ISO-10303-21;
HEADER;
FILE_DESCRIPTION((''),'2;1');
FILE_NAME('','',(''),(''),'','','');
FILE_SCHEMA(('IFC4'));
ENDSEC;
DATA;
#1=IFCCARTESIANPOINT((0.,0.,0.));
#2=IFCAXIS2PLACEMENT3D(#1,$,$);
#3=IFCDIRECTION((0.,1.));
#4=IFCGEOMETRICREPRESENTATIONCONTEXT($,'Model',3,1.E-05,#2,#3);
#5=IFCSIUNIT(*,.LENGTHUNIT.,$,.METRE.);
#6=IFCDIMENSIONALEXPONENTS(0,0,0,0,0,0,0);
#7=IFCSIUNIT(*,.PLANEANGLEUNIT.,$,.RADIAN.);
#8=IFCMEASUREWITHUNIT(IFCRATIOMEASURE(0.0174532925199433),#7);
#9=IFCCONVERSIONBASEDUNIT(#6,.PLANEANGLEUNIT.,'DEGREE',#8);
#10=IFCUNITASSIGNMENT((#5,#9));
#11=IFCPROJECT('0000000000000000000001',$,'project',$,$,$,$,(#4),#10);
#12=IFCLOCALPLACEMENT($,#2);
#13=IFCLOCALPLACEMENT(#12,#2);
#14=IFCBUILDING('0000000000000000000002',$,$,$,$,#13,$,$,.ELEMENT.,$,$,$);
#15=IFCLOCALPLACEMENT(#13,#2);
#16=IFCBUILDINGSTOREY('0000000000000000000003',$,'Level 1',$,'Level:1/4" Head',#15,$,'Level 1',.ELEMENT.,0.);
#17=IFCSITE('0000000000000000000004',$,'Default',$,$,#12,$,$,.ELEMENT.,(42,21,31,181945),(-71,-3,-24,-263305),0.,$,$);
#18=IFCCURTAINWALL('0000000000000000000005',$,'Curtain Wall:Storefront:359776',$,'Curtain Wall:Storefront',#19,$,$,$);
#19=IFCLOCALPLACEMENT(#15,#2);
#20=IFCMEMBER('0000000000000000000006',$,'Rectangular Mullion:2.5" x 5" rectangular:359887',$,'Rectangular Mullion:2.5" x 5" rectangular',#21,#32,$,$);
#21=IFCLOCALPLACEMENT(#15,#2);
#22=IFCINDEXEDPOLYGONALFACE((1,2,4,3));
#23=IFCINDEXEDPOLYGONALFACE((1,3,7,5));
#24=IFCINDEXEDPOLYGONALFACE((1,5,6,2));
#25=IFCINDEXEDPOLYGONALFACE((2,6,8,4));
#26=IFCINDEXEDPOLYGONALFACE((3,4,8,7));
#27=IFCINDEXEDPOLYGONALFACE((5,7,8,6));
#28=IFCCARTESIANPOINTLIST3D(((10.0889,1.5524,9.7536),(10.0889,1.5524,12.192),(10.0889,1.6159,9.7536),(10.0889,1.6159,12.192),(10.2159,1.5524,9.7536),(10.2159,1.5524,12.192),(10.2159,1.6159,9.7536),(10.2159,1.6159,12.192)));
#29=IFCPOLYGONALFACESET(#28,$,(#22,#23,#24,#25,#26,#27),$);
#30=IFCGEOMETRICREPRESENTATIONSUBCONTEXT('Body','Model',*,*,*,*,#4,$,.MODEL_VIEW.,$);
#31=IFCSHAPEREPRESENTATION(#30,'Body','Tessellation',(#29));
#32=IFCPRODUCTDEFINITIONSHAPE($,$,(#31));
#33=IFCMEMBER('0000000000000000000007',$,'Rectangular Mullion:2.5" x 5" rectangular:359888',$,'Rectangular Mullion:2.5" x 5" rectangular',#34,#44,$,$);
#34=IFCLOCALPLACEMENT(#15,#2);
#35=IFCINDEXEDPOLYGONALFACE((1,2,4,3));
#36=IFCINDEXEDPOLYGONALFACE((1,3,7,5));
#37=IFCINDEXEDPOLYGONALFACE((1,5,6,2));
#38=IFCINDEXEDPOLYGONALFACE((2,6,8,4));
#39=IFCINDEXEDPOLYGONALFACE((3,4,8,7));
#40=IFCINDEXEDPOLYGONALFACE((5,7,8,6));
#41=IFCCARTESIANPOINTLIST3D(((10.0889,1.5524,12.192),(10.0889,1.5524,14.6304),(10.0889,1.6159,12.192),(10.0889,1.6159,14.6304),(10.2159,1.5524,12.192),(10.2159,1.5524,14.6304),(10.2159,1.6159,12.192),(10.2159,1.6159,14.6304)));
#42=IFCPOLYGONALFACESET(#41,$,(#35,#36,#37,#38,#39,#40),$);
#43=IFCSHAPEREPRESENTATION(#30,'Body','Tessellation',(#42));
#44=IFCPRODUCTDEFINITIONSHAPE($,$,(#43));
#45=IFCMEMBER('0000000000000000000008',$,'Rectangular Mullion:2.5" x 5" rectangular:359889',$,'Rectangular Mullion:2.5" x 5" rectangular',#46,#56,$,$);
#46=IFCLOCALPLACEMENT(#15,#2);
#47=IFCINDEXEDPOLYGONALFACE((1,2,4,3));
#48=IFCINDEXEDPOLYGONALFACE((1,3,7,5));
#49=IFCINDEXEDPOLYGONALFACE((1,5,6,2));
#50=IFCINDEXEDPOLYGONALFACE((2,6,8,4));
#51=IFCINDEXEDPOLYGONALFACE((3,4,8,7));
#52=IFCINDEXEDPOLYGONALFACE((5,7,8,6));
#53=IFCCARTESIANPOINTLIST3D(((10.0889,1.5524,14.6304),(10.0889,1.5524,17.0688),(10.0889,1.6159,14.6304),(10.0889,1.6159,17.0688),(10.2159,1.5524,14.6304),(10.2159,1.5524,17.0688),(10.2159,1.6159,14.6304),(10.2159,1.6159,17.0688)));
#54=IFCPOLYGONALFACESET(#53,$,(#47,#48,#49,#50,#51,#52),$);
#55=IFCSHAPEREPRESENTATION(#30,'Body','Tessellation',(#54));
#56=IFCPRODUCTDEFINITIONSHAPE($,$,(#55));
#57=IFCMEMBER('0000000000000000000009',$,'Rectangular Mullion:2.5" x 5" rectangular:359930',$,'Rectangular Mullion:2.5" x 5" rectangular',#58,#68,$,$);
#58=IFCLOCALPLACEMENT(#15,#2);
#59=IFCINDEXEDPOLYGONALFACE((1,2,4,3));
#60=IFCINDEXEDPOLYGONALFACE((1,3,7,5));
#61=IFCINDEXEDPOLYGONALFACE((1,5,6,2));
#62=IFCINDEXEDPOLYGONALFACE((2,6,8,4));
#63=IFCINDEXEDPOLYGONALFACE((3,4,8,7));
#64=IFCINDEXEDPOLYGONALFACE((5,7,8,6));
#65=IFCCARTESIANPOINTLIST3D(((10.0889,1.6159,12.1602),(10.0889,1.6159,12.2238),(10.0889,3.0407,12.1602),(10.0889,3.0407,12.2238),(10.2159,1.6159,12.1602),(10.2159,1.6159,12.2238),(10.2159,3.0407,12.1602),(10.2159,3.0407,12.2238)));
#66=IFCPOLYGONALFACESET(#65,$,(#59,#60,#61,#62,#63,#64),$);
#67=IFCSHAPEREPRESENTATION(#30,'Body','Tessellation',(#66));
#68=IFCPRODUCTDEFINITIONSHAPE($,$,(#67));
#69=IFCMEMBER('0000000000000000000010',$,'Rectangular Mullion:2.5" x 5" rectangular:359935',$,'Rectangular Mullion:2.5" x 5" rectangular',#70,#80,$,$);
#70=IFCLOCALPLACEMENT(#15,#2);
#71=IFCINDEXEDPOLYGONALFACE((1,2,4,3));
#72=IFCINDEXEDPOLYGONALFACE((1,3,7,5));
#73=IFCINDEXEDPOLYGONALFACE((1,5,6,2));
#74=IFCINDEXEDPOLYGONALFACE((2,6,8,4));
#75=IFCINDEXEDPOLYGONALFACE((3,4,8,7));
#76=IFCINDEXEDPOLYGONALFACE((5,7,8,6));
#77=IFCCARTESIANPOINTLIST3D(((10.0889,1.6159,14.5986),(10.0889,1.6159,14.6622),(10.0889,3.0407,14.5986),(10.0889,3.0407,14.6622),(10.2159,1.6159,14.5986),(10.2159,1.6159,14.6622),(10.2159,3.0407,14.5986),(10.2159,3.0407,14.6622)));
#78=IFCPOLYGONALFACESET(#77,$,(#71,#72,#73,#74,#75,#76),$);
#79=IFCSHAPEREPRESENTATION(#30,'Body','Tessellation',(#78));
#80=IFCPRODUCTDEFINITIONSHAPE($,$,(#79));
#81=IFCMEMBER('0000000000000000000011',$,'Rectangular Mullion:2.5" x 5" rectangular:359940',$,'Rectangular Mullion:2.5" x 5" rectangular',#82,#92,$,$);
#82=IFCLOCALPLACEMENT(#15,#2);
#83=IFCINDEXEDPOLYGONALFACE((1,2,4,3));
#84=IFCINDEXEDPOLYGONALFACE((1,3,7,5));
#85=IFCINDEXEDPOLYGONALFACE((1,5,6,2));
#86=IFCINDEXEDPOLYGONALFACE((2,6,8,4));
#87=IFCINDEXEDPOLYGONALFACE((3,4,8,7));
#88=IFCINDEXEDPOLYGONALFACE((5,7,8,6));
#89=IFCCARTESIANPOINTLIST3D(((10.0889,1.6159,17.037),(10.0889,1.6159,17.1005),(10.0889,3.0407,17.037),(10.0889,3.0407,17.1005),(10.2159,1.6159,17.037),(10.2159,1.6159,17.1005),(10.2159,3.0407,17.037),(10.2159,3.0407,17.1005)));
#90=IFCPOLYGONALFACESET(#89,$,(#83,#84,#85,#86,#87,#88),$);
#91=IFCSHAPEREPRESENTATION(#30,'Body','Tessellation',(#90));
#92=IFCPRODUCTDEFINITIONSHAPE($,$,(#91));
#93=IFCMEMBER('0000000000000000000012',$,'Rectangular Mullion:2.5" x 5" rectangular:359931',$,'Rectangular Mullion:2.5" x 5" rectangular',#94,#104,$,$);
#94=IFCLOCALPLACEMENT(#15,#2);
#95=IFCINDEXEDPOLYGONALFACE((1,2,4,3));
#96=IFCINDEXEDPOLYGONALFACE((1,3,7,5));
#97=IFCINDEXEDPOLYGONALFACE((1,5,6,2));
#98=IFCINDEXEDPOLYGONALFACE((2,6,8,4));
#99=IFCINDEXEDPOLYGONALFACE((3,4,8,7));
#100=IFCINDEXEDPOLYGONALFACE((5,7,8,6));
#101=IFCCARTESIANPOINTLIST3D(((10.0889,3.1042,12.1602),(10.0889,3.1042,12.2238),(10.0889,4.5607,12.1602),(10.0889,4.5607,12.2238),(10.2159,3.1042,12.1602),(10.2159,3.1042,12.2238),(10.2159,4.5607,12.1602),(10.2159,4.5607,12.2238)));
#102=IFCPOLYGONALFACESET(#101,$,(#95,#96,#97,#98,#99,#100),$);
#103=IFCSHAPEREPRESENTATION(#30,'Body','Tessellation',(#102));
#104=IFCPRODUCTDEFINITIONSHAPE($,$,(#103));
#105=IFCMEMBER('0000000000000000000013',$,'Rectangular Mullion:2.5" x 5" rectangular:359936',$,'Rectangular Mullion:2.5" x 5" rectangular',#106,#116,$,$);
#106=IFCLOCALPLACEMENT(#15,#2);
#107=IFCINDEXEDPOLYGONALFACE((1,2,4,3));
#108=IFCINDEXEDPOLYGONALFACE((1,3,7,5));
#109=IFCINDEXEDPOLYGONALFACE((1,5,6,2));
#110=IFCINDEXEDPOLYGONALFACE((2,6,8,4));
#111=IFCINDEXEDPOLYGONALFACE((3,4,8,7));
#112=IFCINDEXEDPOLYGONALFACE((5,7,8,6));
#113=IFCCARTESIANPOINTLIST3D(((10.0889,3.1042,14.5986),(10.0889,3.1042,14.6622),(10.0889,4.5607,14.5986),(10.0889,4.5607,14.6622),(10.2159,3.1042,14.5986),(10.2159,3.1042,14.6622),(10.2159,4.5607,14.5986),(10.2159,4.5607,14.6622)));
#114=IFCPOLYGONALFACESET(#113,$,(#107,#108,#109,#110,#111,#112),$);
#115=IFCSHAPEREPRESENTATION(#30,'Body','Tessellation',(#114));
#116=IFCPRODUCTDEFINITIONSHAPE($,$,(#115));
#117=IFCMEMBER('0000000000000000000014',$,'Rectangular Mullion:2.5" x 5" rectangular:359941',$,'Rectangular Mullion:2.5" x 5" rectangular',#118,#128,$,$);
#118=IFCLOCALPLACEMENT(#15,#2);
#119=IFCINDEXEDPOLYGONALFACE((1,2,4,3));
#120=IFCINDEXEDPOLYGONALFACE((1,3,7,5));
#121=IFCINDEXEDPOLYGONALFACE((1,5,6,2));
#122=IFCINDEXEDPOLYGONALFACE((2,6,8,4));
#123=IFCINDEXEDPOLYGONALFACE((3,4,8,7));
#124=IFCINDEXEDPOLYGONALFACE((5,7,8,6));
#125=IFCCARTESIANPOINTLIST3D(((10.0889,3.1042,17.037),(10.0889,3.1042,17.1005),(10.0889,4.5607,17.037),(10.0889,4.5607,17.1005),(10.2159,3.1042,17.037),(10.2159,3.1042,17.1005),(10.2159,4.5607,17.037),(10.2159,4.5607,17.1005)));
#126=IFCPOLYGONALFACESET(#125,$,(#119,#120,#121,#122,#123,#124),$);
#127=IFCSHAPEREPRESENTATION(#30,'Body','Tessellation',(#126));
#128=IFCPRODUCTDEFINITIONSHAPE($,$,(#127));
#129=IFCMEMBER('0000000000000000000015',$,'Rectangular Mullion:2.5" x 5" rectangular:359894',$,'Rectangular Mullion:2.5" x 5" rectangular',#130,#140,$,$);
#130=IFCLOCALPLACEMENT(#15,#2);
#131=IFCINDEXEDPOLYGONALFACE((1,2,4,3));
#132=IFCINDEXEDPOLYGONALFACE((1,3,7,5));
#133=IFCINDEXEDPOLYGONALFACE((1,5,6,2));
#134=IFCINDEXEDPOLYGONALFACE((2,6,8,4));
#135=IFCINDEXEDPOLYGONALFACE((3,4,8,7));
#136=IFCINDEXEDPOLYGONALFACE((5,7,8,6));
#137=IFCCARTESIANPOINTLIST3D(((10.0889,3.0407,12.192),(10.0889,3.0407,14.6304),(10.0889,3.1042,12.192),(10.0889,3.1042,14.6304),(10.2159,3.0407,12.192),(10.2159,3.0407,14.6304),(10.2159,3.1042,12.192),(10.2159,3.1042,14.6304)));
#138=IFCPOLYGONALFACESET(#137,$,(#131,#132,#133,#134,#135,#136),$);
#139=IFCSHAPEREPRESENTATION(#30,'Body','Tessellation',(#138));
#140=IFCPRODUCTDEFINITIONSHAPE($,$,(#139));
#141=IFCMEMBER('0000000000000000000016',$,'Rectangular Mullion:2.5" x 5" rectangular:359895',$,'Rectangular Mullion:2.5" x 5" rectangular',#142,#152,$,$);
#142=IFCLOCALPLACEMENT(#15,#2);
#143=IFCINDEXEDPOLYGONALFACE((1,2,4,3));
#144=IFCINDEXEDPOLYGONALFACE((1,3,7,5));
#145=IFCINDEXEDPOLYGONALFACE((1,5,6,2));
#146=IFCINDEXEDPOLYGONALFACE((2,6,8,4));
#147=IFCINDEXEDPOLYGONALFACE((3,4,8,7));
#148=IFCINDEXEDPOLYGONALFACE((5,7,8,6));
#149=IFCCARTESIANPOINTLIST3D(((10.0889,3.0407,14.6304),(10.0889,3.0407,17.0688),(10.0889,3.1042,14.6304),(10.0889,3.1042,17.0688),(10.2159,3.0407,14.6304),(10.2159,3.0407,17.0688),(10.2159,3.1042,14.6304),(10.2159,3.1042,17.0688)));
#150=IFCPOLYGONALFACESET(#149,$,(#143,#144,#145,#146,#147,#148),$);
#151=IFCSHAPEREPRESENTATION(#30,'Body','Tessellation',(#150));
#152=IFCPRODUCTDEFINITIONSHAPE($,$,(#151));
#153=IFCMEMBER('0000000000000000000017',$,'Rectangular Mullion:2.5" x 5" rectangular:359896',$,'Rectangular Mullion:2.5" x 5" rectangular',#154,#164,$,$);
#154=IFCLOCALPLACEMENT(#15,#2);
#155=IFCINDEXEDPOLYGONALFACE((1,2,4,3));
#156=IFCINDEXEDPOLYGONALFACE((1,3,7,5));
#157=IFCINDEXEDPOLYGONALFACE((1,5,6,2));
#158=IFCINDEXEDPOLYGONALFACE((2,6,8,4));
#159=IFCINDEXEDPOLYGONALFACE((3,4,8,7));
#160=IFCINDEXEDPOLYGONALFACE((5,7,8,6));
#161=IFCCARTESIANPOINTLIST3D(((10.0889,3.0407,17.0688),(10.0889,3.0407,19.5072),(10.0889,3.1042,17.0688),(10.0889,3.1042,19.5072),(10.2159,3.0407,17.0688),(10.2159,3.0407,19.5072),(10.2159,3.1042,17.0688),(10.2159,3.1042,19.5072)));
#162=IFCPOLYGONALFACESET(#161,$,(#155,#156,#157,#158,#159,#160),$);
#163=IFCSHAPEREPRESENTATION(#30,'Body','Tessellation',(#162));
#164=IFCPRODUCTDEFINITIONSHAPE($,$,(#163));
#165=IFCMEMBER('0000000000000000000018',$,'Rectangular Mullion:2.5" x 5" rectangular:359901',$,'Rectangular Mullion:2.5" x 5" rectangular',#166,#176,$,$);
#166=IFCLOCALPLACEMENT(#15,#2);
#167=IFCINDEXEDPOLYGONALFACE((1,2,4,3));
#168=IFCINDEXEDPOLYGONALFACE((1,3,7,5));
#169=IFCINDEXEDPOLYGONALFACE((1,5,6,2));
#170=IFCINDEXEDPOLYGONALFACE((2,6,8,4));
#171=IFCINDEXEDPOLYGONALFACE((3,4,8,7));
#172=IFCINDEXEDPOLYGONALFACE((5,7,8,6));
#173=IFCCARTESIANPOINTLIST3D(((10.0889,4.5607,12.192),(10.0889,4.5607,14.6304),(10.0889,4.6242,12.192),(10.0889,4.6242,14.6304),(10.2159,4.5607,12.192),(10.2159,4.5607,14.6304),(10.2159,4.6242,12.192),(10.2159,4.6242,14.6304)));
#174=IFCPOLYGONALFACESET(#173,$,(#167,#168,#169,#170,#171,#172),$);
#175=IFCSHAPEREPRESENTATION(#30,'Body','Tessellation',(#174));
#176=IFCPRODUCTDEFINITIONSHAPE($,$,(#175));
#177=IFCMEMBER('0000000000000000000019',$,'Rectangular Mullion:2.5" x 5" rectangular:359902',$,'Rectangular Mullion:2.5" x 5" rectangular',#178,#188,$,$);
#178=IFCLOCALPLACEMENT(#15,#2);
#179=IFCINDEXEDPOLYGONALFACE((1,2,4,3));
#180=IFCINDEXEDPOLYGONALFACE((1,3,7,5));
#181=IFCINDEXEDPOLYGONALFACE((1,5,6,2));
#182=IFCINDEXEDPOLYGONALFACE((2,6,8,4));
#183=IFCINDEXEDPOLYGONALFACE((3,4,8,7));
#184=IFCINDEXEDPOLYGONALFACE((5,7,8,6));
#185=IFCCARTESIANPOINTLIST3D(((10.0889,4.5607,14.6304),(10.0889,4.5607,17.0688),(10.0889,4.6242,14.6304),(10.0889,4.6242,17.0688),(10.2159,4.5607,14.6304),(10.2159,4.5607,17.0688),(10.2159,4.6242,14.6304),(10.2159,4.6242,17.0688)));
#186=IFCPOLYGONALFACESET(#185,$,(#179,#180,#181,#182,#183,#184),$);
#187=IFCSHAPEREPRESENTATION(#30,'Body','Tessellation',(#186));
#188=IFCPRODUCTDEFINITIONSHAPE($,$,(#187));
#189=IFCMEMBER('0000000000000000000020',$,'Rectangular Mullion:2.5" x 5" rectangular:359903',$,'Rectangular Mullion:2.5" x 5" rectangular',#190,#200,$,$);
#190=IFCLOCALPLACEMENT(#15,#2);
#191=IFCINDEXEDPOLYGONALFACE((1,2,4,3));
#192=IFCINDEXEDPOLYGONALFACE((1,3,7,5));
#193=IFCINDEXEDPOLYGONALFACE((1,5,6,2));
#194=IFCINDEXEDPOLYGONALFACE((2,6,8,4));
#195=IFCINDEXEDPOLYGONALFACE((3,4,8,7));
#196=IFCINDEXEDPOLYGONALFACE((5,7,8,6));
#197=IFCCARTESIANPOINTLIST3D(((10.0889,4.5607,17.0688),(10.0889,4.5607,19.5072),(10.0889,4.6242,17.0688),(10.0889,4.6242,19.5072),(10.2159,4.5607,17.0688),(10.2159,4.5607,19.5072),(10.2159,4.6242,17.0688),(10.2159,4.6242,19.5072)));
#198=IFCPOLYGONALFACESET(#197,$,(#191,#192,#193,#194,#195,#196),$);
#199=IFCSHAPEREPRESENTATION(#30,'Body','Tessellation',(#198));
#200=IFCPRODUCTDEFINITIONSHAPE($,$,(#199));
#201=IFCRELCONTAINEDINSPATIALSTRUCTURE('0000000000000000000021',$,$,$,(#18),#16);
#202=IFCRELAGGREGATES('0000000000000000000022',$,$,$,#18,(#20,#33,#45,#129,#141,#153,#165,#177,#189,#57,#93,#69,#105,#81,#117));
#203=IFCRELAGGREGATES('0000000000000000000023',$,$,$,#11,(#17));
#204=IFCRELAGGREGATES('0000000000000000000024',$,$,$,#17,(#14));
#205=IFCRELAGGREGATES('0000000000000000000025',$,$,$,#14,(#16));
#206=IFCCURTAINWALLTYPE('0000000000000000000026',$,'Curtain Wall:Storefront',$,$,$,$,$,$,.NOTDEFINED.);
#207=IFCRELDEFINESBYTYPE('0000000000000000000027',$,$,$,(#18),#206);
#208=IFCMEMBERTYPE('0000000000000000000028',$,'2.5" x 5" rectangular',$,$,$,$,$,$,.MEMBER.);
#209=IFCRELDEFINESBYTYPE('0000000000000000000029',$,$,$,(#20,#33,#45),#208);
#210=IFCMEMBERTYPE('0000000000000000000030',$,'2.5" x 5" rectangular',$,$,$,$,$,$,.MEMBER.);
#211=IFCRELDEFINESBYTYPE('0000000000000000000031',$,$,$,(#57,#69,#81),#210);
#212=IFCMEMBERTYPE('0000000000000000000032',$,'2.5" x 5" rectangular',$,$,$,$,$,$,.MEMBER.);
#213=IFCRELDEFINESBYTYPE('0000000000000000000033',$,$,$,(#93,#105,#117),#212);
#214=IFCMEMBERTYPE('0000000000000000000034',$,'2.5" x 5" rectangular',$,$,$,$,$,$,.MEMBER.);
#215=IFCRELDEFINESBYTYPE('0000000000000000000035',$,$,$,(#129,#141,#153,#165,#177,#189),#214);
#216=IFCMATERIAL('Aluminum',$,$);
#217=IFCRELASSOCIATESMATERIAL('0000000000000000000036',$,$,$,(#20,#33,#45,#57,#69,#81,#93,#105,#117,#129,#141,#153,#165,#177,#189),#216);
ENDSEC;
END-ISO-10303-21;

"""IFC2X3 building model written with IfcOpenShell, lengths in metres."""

from ifc_helpers import new_model, entity, si_unit, converted_unit, direction, frame, origin, origin_2d_with_axis, place, context, subcontext, project, spatial, rectangle, extrude, source, transform, mapped, material, type_object, type_shapes, element, aggregate, save


model = new_model("IFC2X3")

# Units and contexts
model_context = context("Model", 3, precision=1e-05, world=origin(), true_north=direction((0.0, 1.0)))
body_context = subcontext(model_context, "Body", "Model", "MODEL_VIEW")
ifc_project = project(units=[si_unit("LENGTHUNIT", "METRE"), converted_unit("PLANEANGLEUNIT", "DEGREE", entity("IfcRatioMeasure", 0.0174532925199433), si_unit("PLANEANGLEUNIT", "RADIAN"), dimensions=[0, 0, 0, 0, 0, 0, 0])], contexts=[model_context])

# Site, building, storey
site_placement = place(None, origin())
site = spatial("IfcSite", under=ifc_project, at=site_placement, Name="Default", CompositionType="ELEMENT", RefLatitude=(42, 21, 31, 181945), RefLongitude=(-71, -3, -24, -263305), RefElevation=0.0)
building_placement = place(site_placement, origin())
building = spatial("IfcBuilding", under=site, at=building_placement, CompositionType="ELEMENT")
storey_placement = place(building_placement, origin())
storey = spatial("IfcBuildingStorey", under=building, at=storey_placement, Name="Level 1", ObjectType="Level:1/4\" Head", LongName="Level 1", CompositionType="ELEMENT", Elevation=0.0)

# Curtain wall, members
curtain_wall_type = type_object("IfcCurtainWallType", Name="Curtain Wall:Storefront", PredefinedType="NOTDEFINED")
curtain_wall_placement = place(storey_placement, origin())
curtain_wall = element("IfcCurtainWall", 1, at=curtain_wall_placement, inside=storey, type_object=curtain_wall_type, Name="Curtain Wall:Storefront:359776", ObjectType="Curtain Wall:Storefront")
ifc_material_1 = material(Name="Aluminum")
member_type_1 = type_object("IfcMemberType", Name="2.5\" x 5\" rectangular", PredefinedType="MEMBER")
shared_shape_1 = source(origin(), body_context, "Body", "SweptSolid", [
    extrude(rectangle(XDim=0.127, YDim=0.0635, at=origin_2d_with_axis()), frame((-0.0318, 0.0, -2.4384), z_axis=(0.0, 0.0, 1.0), x_axis=(0.0, -1.0, 0.0)), (0.0, 0.0, 1.0), 2.4384),
])
type_shapes(member_type_1, [shared_shape_1])
member_1_placement = place(storey_placement, frame((10.1524, 1.5524, 12.192), z_axis=(0.0, 0.0, 1.0), x_axis=(0.0, -1.0, 0.0)))
member_1 = element("IfcMember", 2, at=member_1_placement, type_object=member_type_1, material=ifc_material_1, Name="Rectangular Mullion:2.5\" x 5\" rectangular:359887", ObjectType="Rectangular Mullion:2.5\" x 5\" rectangular", context=body_context, shape_type="MappedRepresentation", body=[
    mapped(shared_shape_1, transform((0.0, 0.0, 0.0), scale=1.0)),
])
member_2_placement = place(storey_placement, frame((10.1524, 1.5524, 14.6304), z_axis=(0.0, 0.0, 1.0), x_axis=(0.0, -1.0, 0.0)))
member_2 = element("IfcMember", 3, at=member_2_placement, type_object=member_type_1, material=ifc_material_1, Name="Rectangular Mullion:2.5\" x 5\" rectangular:359888", ObjectType="Rectangular Mullion:2.5\" x 5\" rectangular", context=body_context, shape_type="MappedRepresentation", body=[
    mapped(shared_shape_1, transform((0.0, 0.0, 0.0), scale=1.0)),
])
member_3_placement = place(storey_placement, frame((10.1524, 1.5524, 17.0688), z_axis=(0.0, 0.0, 1.0), x_axis=(0.0, -1.0, 0.0)))
member_3 = element("IfcMember", 4, at=member_3_placement, type_object=member_type_1, material=ifc_material_1, Name="Rectangular Mullion:2.5\" x 5\" rectangular:359889", ObjectType="Rectangular Mullion:2.5\" x 5\" rectangular", context=body_context, shape_type="MappedRepresentation", body=[
    mapped(shared_shape_1, transform((0.0, 0.0, 0.0), scale=1.0)),
])
member_type_2 = type_object("IfcMemberType", Name="2.5\" x 5\" rectangular", PredefinedType="MEMBER")
shared_shape_2 = source(origin(), body_context, "Body", "SweptSolid", [
    extrude(rectangle(XDim=0.127, YDim=0.0635, at=origin_2d_with_axis()), frame((0.0, 0.0, -1.4248), z_axis=(0.0, 0.0, 1.0), x_axis=(0.0, -1.0, 0.0)), (0.0, 0.0, 1.0), 1.4248),
])
type_shapes(member_type_2, [shared_shape_2])
member_4_placement = place(storey_placement, frame((10.1524, 3.0407, 12.192), z_axis=(0.0, 1.0, 0.0), x_axis=(0.0, 0.0, 1.0)))
member_4 = element("IfcMember", 5, at=member_4_placement, type_object=member_type_2, material=ifc_material_1, Name="Rectangular Mullion:2.5\" x 5\" rectangular:359930", ObjectType="Rectangular Mullion:2.5\" x 5\" rectangular", context=body_context, shape_type="MappedRepresentation", body=[
    mapped(shared_shape_2, transform((0.0, 0.0, 0.0), scale=1.0)),
])
member_5_placement = place(storey_placement, frame((10.1524, 3.0407, 14.6304), z_axis=(0.0, 1.0, 0.0), x_axis=(0.0, 0.0, 1.0)))
member_5 = element("IfcMember", 6, at=member_5_placement, type_object=member_type_2, material=ifc_material_1, Name="Rectangular Mullion:2.5\" x 5\" rectangular:359935", ObjectType="Rectangular Mullion:2.5\" x 5\" rectangular", context=body_context, shape_type="MappedRepresentation", body=[
    mapped(shared_shape_2, transform((0.0, 0.0, 0.0), scale=1.0)),
])
member_6_placement = place(storey_placement, frame((10.1524, 3.0407, 17.0688), z_axis=(0.0, 1.0, 0.0), x_axis=(0.0, 0.0, 1.0)))
member_6 = element("IfcMember", 7, at=member_6_placement, type_object=member_type_2, material=ifc_material_1, Name="Rectangular Mullion:2.5\" x 5\" rectangular:359940", ObjectType="Rectangular Mullion:2.5\" x 5\" rectangular", context=body_context, shape_type="MappedRepresentation", body=[
    mapped(shared_shape_2, transform((0.0, 0.0, 0.0), scale=1.0)),
])
member_type_3 = type_object("IfcMemberType", Name="2.5\" x 5\" rectangular", PredefinedType="MEMBER")
shared_shape_3 = source(origin(), body_context, "Body", "SweptSolid", [
    extrude(rectangle(XDim=0.127, YDim=0.0635, at=origin_2d_with_axis()), frame((0.0, 0.0, -1.4565), z_axis=(0.0, 0.0, 1.0), x_axis=(0.0, -1.0, 0.0)), (0.0, 0.0, 1.0), 1.4565),
])
type_shapes(member_type_3, [shared_shape_3])
member_7_placement = place(storey_placement, frame((10.1524, 4.5607, 12.192), z_axis=(0.0, 1.0, 0.0), x_axis=(0.0, 0.0, 1.0)))
member_7 = element("IfcMember", 8, at=member_7_placement, type_object=member_type_3, material=ifc_material_1, Name="Rectangular Mullion:2.5\" x 5\" rectangular:359931", ObjectType="Rectangular Mullion:2.5\" x 5\" rectangular", context=body_context, shape_type="MappedRepresentation", body=[
    mapped(shared_shape_3, transform((0.0, 0.0, 0.0), scale=1.0)),
])
member_8_placement = place(storey_placement, frame((10.1524, 4.5607, 14.6304), z_axis=(0.0, 1.0, 0.0), x_axis=(0.0, 0.0, 1.0)))
member_8 = element("IfcMember", 9, at=member_8_placement, type_object=member_type_3, material=ifc_material_1, Name="Rectangular Mullion:2.5\" x 5\" rectangular:359936", ObjectType="Rectangular Mullion:2.5\" x 5\" rectangular", context=body_context, shape_type="MappedRepresentation", body=[
    mapped(shared_shape_3, transform((0.0, 0.0, 0.0), scale=1.0)),
])
member_9_placement = place(storey_placement, frame((10.1524, 4.5607, 17.0688), z_axis=(0.0, 1.0, 0.0), x_axis=(0.0, 0.0, 1.0)))
member_9 = element("IfcMember", 10, at=member_9_placement, type_object=member_type_3, material=ifc_material_1, Name="Rectangular Mullion:2.5\" x 5\" rectangular:359941", ObjectType="Rectangular Mullion:2.5\" x 5\" rectangular", context=body_context, shape_type="MappedRepresentation", body=[
    mapped(shared_shape_3, transform((0.0, 0.0, 0.0), scale=1.0)),
])
member_type_4 = type_object("IfcMemberType", Name="2.5\" x 5\" rectangular", PredefinedType="MEMBER")
shared_shape_4 = source(origin(), body_context, "Body", "SweptSolid", [
    extrude(rectangle(XDim=0.127, YDim=0.0635, at=origin_2d_with_axis()), frame((0.0, 0.0, -2.4384), z_axis=(0.0, 0.0, 1.0), x_axis=(0.0, -1.0, 0.0)), (0.0, 0.0, 1.0), 2.4384),
])
type_shapes(member_type_4, [shared_shape_4])
member_10_placement = place(storey_placement, frame((10.1524, 3.0724, 12.192), z_axis=(0.0, 0.0, -1.0), x_axis=(0.0, 1.0, 0.0)))
member_10 = element("IfcMember", 11, at=member_10_placement, type_object=member_type_4, material=ifc_material_1, Name="Rectangular Mullion:2.5\" x 5\" rectangular:359894", ObjectType="Rectangular Mullion:2.5\" x 5\" rectangular", context=body_context, shape_type="MappedRepresentation", body=[
    mapped(shared_shape_4, transform((0.0, 0.0, 0.0), scale=1.0)),
])
member_11_placement = place(storey_placement, frame((10.1524, 3.0724, 14.6304), z_axis=(0.0, 0.0, -1.0), x_axis=(0.0, 1.0, 0.0)))
member_11 = element("IfcMember", 12, at=member_11_placement, type_object=member_type_4, material=ifc_material_1, Name="Rectangular Mullion:2.5\" x 5\" rectangular:359895", ObjectType="Rectangular Mullion:2.5\" x 5\" rectangular", context=body_context, shape_type="MappedRepresentation", body=[
    mapped(shared_shape_4, transform((0.0, 0.0, 0.0), scale=1.0)),
])
member_12_placement = place(storey_placement, frame((10.1524, 3.0724, 17.0688), z_axis=(0.0, 0.0, -1.0), x_axis=(0.0, 1.0, 0.0)))
member_12 = element("IfcMember", 13, at=member_12_placement, type_object=member_type_4, material=ifc_material_1, Name="Rectangular Mullion:2.5\" x 5\" rectangular:359896", ObjectType="Rectangular Mullion:2.5\" x 5\" rectangular", context=body_context, shape_type="MappedRepresentation", body=[
    mapped(shared_shape_4, transform((0.0, 0.0, 0.0), scale=1.0)),
])
member_13_placement = place(storey_placement, frame((10.1524, 4.5924, 12.192), z_axis=(0.0, 0.0, -1.0), x_axis=(0.0, 1.0, 0.0)))
member_13 = element("IfcMember", 14, at=member_13_placement, type_object=member_type_4, material=ifc_material_1, Name="Rectangular Mullion:2.5\" x 5\" rectangular:359901", ObjectType="Rectangular Mullion:2.5\" x 5\" rectangular", context=body_context, shape_type="MappedRepresentation", body=[
    mapped(shared_shape_4, transform((0.0, 0.0, 0.0), scale=1.0)),
])
member_14_placement = place(storey_placement, frame((10.1524, 4.5924, 14.6304), z_axis=(0.0, 0.0, -1.0), x_axis=(0.0, 1.0, 0.0)))
member_14 = element("IfcMember", 15, at=member_14_placement, type_object=member_type_4, material=ifc_material_1, Name="Rectangular Mullion:2.5\" x 5\" rectangular:359902", ObjectType="Rectangular Mullion:2.5\" x 5\" rectangular", context=body_context, shape_type="MappedRepresentation", body=[
    mapped(shared_shape_4, transform((0.0, 0.0, 0.0), scale=1.0)),
])
member_15_placement = place(storey_placement, frame((10.1524, 4.5924, 17.0688), z_axis=(0.0, 0.0, -1.0), x_axis=(0.0, 1.0, 0.0)))
member_15 = element("IfcMember", 16, at=member_15_placement, type_object=member_type_4, material=ifc_material_1, Name="Rectangular Mullion:2.5\" x 5\" rectangular:359903", ObjectType="Rectangular Mullion:2.5\" x 5\" rectangular", context=body_context, shape_type="MappedRepresentation", body=[
    mapped(shared_shape_4, transform((0.0, 0.0, 0.0), scale=1.0)),
])
aggregate(curtain_wall, [member_1, member_2, member_3, member_10, member_11, member_12, member_13, member_14, member_15, member_4, member_7, member_5, member_8, member_6, member_9])

save(model, "model.ifc")
